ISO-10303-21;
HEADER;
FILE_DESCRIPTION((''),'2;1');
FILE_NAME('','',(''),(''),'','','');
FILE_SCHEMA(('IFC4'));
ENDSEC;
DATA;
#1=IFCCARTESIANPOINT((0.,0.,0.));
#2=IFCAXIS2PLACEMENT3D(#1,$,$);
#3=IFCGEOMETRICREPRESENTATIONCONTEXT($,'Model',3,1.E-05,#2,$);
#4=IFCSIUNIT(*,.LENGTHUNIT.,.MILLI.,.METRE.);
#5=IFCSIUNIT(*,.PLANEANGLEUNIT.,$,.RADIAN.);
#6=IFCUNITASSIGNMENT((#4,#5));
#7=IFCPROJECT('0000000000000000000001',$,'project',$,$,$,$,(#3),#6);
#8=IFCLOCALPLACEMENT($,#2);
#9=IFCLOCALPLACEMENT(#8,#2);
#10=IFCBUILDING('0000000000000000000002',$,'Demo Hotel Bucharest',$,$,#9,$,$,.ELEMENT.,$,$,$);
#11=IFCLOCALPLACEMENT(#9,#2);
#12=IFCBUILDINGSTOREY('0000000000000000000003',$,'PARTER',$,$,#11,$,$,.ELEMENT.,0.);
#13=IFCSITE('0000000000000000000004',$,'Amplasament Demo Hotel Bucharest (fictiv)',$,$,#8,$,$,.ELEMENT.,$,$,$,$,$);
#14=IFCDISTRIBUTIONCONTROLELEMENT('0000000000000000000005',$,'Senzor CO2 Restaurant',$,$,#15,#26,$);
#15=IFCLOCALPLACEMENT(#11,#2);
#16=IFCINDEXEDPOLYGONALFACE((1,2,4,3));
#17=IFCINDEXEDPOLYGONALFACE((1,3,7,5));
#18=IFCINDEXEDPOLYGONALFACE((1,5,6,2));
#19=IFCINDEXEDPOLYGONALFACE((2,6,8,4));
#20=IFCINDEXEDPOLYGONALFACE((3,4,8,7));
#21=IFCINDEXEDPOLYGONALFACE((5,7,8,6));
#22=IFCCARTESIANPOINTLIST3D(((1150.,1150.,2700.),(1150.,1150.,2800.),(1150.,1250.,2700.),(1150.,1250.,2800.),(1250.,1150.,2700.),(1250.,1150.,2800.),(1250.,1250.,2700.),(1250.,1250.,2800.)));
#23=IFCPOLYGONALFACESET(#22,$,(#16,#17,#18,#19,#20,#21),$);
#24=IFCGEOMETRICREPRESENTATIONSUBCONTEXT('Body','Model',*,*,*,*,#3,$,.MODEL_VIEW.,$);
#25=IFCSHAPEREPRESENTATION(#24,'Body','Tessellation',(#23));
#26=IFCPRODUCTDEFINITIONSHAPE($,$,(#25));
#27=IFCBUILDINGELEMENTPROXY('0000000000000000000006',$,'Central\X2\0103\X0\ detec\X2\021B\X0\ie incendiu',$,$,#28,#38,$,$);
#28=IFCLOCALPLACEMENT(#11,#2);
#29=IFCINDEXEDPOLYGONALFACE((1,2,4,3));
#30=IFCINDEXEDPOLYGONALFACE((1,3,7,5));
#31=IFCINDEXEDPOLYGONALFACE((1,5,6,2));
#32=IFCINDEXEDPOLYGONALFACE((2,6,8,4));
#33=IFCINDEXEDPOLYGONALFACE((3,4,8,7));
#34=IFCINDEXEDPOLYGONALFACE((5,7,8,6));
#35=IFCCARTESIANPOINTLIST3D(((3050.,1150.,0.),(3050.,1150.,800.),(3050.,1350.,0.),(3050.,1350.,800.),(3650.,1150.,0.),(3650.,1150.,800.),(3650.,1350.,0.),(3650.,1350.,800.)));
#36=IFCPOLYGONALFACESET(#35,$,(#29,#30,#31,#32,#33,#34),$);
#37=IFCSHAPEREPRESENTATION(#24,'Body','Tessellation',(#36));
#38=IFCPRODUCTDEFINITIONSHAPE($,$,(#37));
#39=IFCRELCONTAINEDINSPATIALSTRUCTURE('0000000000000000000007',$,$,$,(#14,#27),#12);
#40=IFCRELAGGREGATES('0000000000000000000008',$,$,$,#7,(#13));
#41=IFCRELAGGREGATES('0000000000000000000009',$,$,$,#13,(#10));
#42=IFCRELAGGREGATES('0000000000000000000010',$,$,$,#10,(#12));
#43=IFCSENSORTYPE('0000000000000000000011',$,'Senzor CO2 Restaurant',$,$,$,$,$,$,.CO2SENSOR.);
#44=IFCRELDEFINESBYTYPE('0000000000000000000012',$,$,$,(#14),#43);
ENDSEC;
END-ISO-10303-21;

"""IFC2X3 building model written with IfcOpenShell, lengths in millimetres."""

from ifc_helpers import new_model, si_unit, frame, frame_2d, origin, place, context, subcontext, project, spatial, rectangle, extrude, type_object, element, save


model = new_model("IFC2X3")

# Units and contexts
model_context = context("Model", 3, precision=1e-05, world=origin())
body_context = subcontext(model_context, "Body", "Model", "MODEL_VIEW")
ifc_project = project(units=[si_unit("LENGTHUNIT", "METRE", prefix="MILLI"), si_unit("PLANEANGLEUNIT", "RADIAN")], contexts=[model_context])

# Site, building, storey
site_placement = place(None, origin())
site = spatial("IfcSite", under=ifc_project, at=site_placement, Name="Amplasament Demo Hotel Bucharest (fictiv)", CompositionType="ELEMENT")
building_placement = place(site_placement, origin())
building = spatial("IfcBuilding", under=site, at=building_placement, Name="Demo Hotel Bucharest", CompositionType="ELEMENT")
storey_placement = place(building_placement, origin())
storey = spatial("IfcBuildingStorey", under=building, at=storey_placement, Name="PARTER", CompositionType="ELEMENT", Elevation=0.0)

# Distribution control element
sensor_type = type_object("IfcSensorType", Name="Senzor CO2 Restaurant", PredefinedType="CO2SENSOR")
distribution_control_element_placement = place(storey_placement, frame((1150.0, 1150.0, 2700.0)))
element("IfcDistributionControlElement", 1, at=distribution_control_element_placement, inside=storey, type_object=sensor_type, Name="Senzor CO2 Restaurant", context=body_context, shape_type="SweptSolid", body=[
    extrude(rectangle(XDim=100.0, YDim=100.0, at=frame_2d((50.0, 50.0))), origin(), (0.0, 0.0, 1.0), 100.0),
])

# Electric distribution point
electric_distribution_point_placement = place(storey_placement, frame((3050.0, 1150.0, 0.0)))
element("IfcElectricDistributionPoint", 2, at=electric_distribution_point_placement, inside=storey, Name="Centrală detecție incendiu", DistributionPointFunction="ALARMPANEL", context=body_context, shape_type="SweptSolid", body=[
    extrude(rectangle(XDim=600.0, YDim=200.0, at=frame_2d((300.0, 100.0))), origin(), (0.0, 0.0, 1.0), 800.0),
])

save(model, "model.ifc")
